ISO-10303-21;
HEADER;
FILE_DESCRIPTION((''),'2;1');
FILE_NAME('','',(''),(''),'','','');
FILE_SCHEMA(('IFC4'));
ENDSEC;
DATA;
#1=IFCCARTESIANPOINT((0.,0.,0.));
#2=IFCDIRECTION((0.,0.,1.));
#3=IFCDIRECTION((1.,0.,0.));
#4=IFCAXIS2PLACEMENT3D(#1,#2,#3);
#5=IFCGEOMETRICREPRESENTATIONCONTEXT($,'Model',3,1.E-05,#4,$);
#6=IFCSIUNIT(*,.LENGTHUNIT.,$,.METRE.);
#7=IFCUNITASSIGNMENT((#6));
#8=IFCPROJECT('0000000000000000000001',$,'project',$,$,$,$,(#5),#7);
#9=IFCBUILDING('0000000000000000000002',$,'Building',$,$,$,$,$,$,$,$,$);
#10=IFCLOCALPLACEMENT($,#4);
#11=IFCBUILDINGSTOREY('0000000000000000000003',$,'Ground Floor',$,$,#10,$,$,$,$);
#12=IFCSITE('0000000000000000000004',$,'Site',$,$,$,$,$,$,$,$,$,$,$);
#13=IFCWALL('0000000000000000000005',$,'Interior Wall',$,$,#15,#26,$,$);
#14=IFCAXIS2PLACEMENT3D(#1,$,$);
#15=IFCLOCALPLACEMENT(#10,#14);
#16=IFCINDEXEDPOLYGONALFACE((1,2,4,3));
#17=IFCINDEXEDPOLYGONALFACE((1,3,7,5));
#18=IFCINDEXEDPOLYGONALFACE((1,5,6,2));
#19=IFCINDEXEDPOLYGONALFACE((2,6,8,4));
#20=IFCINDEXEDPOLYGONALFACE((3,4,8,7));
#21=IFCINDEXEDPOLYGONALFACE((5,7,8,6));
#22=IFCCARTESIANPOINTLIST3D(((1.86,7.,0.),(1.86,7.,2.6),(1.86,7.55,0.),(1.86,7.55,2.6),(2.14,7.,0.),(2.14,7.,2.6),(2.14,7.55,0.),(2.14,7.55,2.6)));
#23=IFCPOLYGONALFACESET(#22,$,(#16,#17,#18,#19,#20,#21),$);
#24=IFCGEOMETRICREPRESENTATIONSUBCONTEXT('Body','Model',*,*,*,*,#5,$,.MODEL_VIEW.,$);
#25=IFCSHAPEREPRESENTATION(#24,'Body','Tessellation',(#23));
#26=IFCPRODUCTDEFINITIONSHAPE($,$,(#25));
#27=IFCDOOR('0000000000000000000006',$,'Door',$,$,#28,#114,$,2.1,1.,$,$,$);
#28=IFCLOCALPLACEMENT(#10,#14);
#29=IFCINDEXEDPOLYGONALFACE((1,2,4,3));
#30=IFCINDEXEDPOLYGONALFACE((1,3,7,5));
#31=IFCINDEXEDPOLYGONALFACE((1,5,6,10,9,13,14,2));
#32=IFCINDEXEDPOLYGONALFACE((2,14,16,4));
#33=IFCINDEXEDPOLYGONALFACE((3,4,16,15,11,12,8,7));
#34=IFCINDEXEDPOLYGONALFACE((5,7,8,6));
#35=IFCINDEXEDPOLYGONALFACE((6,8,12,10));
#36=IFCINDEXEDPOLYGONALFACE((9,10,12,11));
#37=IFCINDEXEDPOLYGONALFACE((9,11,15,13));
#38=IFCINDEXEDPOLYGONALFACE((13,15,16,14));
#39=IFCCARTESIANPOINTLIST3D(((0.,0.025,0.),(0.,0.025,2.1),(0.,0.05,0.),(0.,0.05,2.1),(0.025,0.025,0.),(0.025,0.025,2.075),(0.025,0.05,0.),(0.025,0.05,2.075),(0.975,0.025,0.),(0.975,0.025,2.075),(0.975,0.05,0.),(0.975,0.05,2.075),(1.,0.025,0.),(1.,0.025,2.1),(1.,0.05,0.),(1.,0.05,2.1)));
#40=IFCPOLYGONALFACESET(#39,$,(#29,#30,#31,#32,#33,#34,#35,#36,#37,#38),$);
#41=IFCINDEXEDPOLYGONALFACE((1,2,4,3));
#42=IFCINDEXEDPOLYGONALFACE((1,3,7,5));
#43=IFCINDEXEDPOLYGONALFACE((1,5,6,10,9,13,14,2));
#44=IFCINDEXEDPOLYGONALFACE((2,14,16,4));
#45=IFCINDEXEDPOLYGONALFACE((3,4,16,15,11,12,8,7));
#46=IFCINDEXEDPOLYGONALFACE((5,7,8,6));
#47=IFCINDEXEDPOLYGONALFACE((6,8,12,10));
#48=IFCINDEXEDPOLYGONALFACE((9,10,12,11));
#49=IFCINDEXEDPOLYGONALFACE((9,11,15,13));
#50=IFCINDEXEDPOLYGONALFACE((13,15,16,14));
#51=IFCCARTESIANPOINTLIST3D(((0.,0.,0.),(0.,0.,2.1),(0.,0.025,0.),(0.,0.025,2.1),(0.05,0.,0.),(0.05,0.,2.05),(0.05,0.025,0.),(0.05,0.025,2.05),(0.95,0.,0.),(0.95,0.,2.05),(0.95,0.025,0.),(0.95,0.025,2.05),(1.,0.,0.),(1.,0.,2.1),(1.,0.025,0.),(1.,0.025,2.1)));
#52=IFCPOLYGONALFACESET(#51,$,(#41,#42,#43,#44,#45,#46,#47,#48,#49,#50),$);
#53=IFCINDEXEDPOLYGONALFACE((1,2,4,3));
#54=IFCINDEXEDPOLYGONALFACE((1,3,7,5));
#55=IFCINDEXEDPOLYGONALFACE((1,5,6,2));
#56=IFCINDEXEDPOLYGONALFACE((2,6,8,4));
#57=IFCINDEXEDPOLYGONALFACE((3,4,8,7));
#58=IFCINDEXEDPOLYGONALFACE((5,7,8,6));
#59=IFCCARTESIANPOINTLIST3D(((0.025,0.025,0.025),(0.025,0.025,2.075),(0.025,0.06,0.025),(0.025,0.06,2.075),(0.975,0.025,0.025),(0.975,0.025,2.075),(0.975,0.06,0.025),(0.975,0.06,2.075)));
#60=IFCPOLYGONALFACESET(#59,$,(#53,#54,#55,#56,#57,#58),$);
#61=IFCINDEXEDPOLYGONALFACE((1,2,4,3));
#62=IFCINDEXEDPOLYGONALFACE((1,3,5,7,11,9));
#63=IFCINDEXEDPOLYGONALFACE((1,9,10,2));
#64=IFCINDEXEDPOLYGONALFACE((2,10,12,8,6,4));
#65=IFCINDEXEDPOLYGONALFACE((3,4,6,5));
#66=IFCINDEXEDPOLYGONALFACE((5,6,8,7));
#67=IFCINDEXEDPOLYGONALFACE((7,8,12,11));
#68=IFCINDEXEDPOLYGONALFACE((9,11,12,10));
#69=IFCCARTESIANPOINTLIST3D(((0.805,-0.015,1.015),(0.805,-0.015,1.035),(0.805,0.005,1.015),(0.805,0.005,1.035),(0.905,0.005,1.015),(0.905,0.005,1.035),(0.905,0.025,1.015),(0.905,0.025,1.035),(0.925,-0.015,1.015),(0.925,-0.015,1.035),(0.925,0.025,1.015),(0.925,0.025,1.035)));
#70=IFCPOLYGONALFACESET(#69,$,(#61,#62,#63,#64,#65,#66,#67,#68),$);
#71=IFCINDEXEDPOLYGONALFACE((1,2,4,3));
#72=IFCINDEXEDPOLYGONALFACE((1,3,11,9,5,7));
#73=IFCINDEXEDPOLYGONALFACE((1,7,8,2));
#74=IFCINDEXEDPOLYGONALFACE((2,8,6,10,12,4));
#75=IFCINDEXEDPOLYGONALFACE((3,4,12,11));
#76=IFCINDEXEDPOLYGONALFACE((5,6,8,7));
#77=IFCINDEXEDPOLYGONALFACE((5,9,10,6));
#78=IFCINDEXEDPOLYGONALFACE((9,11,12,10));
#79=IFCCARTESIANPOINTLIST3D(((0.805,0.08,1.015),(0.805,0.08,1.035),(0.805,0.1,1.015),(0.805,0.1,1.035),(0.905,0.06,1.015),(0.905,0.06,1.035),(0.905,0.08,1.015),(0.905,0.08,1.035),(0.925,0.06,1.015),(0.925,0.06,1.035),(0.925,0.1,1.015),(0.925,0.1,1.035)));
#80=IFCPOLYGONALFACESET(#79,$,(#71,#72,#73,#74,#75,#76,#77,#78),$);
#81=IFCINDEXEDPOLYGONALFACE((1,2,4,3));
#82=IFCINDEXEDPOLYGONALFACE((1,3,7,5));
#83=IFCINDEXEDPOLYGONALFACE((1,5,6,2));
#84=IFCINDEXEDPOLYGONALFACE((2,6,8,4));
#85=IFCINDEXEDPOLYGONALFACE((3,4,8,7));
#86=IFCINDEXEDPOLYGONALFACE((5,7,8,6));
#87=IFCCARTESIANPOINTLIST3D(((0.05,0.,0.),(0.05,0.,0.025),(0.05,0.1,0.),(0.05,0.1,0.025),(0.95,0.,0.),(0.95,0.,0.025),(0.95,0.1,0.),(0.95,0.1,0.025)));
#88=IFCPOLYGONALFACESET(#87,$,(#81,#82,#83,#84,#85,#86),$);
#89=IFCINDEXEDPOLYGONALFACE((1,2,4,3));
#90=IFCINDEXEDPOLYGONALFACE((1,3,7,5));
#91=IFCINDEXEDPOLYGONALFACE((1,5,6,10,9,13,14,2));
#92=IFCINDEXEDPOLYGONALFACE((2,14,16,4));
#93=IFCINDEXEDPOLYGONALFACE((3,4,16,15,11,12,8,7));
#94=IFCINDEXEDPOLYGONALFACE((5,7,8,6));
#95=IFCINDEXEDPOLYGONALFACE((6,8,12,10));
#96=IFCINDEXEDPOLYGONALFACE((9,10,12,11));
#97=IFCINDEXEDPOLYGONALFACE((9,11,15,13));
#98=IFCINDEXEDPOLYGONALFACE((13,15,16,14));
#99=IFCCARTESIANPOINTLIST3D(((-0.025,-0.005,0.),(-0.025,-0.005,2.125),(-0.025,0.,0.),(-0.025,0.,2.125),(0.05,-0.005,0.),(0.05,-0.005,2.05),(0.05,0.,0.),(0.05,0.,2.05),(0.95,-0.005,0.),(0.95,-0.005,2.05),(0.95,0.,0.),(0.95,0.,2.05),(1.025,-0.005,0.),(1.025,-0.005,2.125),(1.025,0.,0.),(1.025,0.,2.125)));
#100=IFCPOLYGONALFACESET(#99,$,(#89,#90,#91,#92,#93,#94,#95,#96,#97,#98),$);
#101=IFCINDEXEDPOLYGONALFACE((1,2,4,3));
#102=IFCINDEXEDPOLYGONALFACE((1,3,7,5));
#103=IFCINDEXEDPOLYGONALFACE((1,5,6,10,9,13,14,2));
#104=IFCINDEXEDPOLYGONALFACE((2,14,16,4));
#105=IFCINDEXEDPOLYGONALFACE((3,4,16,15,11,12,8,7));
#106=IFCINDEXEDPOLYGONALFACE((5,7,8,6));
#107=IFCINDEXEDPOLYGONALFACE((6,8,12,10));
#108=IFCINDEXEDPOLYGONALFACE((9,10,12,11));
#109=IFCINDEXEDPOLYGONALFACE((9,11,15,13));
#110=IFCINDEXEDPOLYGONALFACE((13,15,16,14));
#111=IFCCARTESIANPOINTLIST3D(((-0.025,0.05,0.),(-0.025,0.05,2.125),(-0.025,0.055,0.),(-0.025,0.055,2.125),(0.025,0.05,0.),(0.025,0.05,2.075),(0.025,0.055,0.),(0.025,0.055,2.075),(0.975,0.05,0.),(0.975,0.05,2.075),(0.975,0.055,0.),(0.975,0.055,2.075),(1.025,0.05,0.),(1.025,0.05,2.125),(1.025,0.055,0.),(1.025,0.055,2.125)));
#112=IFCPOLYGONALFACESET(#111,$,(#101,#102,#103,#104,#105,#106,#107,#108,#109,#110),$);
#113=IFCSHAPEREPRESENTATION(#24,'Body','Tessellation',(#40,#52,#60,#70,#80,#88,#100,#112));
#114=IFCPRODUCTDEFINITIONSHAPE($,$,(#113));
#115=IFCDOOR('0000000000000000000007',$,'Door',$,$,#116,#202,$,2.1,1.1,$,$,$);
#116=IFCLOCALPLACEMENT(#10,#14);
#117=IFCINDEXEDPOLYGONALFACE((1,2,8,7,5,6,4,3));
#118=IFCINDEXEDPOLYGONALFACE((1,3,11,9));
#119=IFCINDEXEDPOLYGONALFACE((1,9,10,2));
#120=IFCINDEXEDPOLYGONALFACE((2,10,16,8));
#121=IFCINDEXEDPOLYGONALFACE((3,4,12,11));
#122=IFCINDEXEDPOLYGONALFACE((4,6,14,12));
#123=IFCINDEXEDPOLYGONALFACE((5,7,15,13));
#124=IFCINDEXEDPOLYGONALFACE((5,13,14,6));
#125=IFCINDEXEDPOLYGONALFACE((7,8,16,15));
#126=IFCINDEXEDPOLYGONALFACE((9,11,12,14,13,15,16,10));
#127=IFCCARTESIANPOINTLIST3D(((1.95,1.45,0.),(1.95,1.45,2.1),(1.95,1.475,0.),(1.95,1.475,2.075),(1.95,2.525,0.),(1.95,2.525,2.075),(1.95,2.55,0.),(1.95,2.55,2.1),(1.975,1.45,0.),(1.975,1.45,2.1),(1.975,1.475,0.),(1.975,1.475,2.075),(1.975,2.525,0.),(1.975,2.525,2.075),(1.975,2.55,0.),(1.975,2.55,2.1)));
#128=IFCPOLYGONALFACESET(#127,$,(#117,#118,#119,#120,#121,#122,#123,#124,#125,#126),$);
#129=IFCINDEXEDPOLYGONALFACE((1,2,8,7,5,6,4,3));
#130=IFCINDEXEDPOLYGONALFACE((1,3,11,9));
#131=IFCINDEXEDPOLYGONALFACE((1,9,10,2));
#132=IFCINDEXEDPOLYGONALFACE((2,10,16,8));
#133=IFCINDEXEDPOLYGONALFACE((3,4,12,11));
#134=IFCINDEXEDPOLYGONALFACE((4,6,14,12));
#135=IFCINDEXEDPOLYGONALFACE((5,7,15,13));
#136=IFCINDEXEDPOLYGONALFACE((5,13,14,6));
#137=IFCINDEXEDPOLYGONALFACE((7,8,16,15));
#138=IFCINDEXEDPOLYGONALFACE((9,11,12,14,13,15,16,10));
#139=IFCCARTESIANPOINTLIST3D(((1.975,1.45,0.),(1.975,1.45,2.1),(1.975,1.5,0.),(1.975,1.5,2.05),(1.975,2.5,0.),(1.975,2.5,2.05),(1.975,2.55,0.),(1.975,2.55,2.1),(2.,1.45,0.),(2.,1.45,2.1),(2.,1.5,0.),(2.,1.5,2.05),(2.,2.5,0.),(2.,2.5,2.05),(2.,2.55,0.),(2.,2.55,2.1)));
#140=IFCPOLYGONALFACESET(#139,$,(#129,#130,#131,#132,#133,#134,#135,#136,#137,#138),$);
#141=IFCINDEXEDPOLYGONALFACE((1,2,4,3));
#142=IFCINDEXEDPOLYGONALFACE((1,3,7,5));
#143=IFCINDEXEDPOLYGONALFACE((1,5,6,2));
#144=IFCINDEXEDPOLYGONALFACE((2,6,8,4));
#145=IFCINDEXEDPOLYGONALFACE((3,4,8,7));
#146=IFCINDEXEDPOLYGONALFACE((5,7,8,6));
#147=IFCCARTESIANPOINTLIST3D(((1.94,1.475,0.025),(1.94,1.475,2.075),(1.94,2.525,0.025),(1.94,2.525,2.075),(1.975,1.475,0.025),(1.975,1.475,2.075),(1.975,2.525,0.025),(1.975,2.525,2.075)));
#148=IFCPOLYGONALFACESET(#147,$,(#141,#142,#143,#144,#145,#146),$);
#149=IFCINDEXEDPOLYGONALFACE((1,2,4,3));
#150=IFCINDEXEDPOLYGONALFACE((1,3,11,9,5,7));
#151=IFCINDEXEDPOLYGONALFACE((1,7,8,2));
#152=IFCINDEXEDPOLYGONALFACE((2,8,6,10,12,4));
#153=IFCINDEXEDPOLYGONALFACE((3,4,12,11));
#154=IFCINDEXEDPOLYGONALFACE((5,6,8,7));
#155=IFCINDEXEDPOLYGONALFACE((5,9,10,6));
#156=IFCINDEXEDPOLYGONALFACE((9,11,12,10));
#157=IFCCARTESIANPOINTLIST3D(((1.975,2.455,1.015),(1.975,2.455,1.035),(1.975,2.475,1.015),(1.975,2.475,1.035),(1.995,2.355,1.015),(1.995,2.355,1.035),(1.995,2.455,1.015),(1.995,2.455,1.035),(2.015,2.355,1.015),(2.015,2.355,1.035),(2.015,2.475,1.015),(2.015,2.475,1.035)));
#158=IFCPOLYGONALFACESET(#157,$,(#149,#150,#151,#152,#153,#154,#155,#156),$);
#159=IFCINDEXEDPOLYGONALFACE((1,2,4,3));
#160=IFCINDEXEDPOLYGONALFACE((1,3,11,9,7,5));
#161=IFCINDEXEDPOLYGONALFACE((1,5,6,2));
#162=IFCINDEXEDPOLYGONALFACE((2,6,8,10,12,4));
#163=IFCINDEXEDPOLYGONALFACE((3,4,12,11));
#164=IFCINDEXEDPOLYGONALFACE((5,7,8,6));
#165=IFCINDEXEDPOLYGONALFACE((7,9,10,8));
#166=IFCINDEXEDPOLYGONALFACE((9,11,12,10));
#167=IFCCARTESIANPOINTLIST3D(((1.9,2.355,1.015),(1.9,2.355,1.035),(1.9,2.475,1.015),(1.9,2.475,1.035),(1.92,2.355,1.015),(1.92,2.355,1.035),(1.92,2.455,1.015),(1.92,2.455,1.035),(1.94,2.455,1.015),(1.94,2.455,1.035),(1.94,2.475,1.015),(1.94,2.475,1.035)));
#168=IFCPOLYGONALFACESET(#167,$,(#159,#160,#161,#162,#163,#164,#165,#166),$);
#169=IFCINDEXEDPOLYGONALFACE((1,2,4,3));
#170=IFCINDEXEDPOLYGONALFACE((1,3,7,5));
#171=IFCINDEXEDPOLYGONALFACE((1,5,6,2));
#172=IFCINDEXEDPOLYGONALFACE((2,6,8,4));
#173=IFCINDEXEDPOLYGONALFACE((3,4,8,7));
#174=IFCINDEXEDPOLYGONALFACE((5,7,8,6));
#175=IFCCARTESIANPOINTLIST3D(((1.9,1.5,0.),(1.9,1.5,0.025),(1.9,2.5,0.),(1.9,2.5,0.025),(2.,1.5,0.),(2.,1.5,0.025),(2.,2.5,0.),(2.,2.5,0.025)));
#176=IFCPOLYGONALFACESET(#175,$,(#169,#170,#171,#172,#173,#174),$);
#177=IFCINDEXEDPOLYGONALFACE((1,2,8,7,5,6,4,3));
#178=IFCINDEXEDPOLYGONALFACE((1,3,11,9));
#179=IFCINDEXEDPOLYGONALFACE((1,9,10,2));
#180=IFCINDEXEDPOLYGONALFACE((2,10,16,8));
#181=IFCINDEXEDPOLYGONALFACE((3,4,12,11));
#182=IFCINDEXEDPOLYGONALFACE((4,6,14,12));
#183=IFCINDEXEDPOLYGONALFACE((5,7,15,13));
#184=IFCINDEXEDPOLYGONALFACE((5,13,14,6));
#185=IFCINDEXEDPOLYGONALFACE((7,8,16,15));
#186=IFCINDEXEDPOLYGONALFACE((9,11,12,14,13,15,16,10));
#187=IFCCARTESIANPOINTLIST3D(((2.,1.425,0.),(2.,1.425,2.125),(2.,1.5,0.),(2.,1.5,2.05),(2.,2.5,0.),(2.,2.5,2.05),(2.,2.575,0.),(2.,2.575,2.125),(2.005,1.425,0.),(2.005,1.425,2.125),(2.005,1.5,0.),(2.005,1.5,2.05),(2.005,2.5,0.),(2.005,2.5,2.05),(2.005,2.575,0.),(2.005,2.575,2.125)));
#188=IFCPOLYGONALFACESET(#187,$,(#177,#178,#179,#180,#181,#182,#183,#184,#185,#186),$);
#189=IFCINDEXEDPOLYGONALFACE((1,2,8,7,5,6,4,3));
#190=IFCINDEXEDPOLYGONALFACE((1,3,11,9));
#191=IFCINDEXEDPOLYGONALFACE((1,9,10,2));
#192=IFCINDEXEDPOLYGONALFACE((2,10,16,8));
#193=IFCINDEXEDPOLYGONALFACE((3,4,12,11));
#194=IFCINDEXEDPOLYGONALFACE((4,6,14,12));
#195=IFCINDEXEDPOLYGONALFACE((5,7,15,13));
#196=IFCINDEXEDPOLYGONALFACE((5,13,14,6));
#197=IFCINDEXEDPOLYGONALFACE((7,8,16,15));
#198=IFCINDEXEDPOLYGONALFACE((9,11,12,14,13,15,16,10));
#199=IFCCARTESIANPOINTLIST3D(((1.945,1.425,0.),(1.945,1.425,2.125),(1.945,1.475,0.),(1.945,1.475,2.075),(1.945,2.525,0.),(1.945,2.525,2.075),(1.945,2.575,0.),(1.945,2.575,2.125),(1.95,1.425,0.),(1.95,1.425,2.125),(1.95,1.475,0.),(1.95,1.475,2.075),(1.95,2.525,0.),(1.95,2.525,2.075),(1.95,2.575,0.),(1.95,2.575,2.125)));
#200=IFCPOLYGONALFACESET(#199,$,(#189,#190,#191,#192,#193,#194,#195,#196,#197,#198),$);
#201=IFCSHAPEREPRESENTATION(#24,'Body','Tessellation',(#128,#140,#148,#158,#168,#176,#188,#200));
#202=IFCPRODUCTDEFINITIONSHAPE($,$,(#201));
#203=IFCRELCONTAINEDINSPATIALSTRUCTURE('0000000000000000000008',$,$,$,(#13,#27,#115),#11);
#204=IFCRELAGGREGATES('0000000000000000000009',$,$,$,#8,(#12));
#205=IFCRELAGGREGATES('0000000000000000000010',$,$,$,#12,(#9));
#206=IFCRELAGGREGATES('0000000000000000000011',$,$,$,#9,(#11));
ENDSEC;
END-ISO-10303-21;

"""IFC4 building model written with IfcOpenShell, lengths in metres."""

from ifc_helpers import new_model, si_unit, frame, origin_with_axes, place, context, subcontext, project, spatial, line, indexed_curve, outline, extrude, element, save


model = new_model("IFC4")

# Units and contexts
model_context = context("Model", 3, precision=1e-05, world=origin_with_axes())
body_context = subcontext(model_context, "Body", "Model", "MODEL_VIEW")
ifc_project = project(units=[si_unit("LENGTHUNIT", "METRE")], contexts=[model_context])

# Site, building, storey
site = spatial("IfcSite", under=ifc_project, Name="Site")
building = spatial("IfcBuilding", under=site, Name="Building")
storey_placement = place(None, origin_with_axes())
storey = spatial("IfcBuildingStorey", under=building, at=storey_placement, Name="Ground Floor")

# Wall
wall_1_placement = place(storey_placement, frame((2.0, 7.55, 0.0), z_axis=(0.0, 0.0, 1.0), x_axis=(0.0, -1.0, 0.0)))
element("IfcWall", 1, at=wall_1_placement, inside=storey, Name="Interior Wall", context=body_context, shape_type="SweptSolid", body=[
    extrude(outline(indexed_curve([(0.0, 0.0), (0.0, 0.28), (0.55, 0.28), (0.55, 0.0), (0.0, 0.0)], self_intersect=False)), frame((0.0, -0.14, 0.0), z_axis=(0.0, 0.0, 1.0), x_axis=(1.0, 0.0, 0.0)), (0.0, 0.0, 1.0), 2.6),
])

# Doors
door_1_placement = place(storey_placement, origin_with_axes())
element("IfcDoor", 2, at=door_1_placement, inside=storey, Name="Door", OverallHeight=2.1, OverallWidth=1.0, context=body_context, shape_type="SweptSolid", body=[
    extrude(outline(indexed_curve([(0.0, 0.0), (0.0, 2.1), (1.0, 2.1), (1.0, 0.0), (0.975, 0.0), (0.975, 2.075), (0.025, 2.075), (0.025, 0.0)], segments=[line(1, 2, 3, 4, 5, 6, 7, 8, 1)])), frame((0.0, 0.025, 0.0), z_axis=(0.0, -1.0, 0.0), x_axis=(1.0, 0.0, 0.0)), (0.0, 0.0, -1.0), 0.025),
    extrude(outline(indexed_curve([(0.0, 0.0), (0.0, 2.1), (1.0, 2.1), (1.0, 0.0), (0.95, 0.0), (0.95, 2.05), (0.05, 2.05), (0.05, 0.0)], segments=[line(1, 2, 3, 4, 5, 6, 7, 8, 1)])), frame((0.0, 0.0, 0.0), z_axis=(0.0, -1.0, 0.0), x_axis=(1.0, 0.0, 0.0)), (0.0, 0.0, -1.0), 0.025),
    extrude(outline(indexed_curve([(0.0, 0.0), (0.95, 0.0), (0.95, 0.035), (0.0, 0.035)], segments=[line(1, 2, 3, 4, 1)])), frame((0.025, 0.025, 0.025), z_axis=(0.0, 0.0, 1.0), x_axis=(1.0, 0.0, 0.0)), (0.0, 0.0, 1.0), 2.05),
    extrude(outline(indexed_curve([(0.0, 0.0), (0.0, -0.04), (-0.12, -0.04), (-0.12, -0.02), (-0.02, -0.02), (-0.02, 0.0)], segments=[line(1, 2, 3, 4, 5, 6, 1)])), frame((0.925, 0.025, 1.015), z_axis=(0.0, 0.0, 1.0), x_axis=(1.0, 0.0, 0.0)), (0.0, 0.0, 1.0), 0.02),
    extrude(outline(indexed_curve([(0.0, 0.0), (0.0, 0.04), (-0.12, 0.04), (-0.12, 0.02), (-0.02, 0.02), (-0.02, 0.0)], segments=[line(1, 2, 3, 4, 5, 6, 1)])), frame((0.925, 0.06, 1.015), z_axis=(0.0, 0.0, 1.0), x_axis=(1.0, 0.0, 0.0)), (0.0, 0.0, 1.0), 0.02),
    extrude(outline(indexed_curve([(0.0, 0.0), (0.9, 0.0), (0.9, 0.1), (0.0, 0.1)], segments=[line(1, 2, 3, 4, 1)])), frame((0.05, 0.0, 0.0), z_axis=(0.0, 0.0, 1.0), x_axis=(1.0, 0.0, 0.0)), (0.0, 0.0, 1.0), 0.025),
    extrude(outline(indexed_curve([(0.0, 0.0), (0.0, 2.125), (1.05, 2.125), (1.05, 0.0), (0.975, 0.0), (0.975, 2.05), (0.075, 2.05), (0.075, 0.0)], segments=[line(1, 2, 3, 4, 5, 6, 7, 8, 1)])), frame((-0.025, -0.005, 0.0), z_axis=(0.0, -1.0, 0.0), x_axis=(1.0, 0.0, 0.0)), (0.0, 0.0, -1.0), 0.005),
    extrude(outline(indexed_curve([(0.0, 0.0), (0.0, 2.125), (1.05, 2.125), (1.05, 0.0), (1.0, 0.0), (1.0, 2.075), (0.05, 2.075), (0.05, 0.0)], segments=[line(1, 2, 3, 4, 5, 6, 7, 8, 1)])), frame((-0.025, 0.05, 0.0), z_axis=(0.0, -1.0, 0.0), x_axis=(1.0, 0.0, 0.0)), (0.0, 0.0, -1.0), 0.005),
])
door_2_placement = place(storey_placement, frame((2.0, 1.45, 0.0), z_axis=(0.0, 0.0, 1.0), x_axis=(0.0, 1.0, 0.0)))
element("IfcDoor", 3, at=door_2_placement, inside=storey, Name="Door", OverallHeight=2.1, OverallWidth=1.1, context=body_context, shape_type="SweptSolid", body=[
    extrude(outline(indexed_curve([(0.0, 0.0), (0.0, 2.1), (1.1, 2.1), (1.1, 0.0), (1.075, 0.0), (1.075, 2.075), (0.025, 2.075), (0.025, 0.0)], segments=[line(1, 2, 3, 4, 5, 6, 7, 8, 1)])), frame((0.0, 0.025, 0.0), z_axis=(0.0, -1.0, 0.0), x_axis=(1.0, 0.0, 0.0)), (0.0, 0.0, -1.0), 0.025),
    extrude(outline(indexed_curve([(0.0, 0.0), (0.0, 2.1), (1.1, 2.1), (1.1, 0.0), (1.05, 0.0), (1.05, 2.05), (0.05, 2.05), (0.05, 0.0)], segments=[line(1, 2, 3, 4, 5, 6, 7, 8, 1)])), frame((0.0, 0.0, 0.0), z_axis=(0.0, -1.0, 0.0), x_axis=(1.0, 0.0, 0.0)), (0.0, 0.0, -1.0), 0.025),
    extrude(outline(indexed_curve([(0.0, 0.0), (1.05, 0.0), (1.05, 0.035), (0.0, 0.035)], segments=[line(1, 2, 3, 4, 1)])), frame((0.025, 0.025, 0.025), z_axis=(0.0, 0.0, 1.0), x_axis=(1.0, 0.0, 0.0)), (0.0, 0.0, 1.0), 2.05),
    extrude(outline(indexed_curve([(0.0, 0.0), (0.0, -0.04), (-0.12, -0.04), (-0.12, -0.02), (-0.02, -0.02), (-0.02, 0.0)], segments=[line(1, 2, 3, 4, 5, 6, 1)])), frame((1.025, 0.025, 1.015), z_axis=(0.0, 0.0, 1.0), x_axis=(1.0, 0.0, 0.0)), (0.0, 0.0, 1.0), 0.02),
    extrude(outline(indexed_curve([(0.0, 0.0), (0.0, 0.04), (-0.12, 0.04), (-0.12, 0.02), (-0.02, 0.02), (-0.02, 0.0)], segments=[line(1, 2, 3, 4, 5, 6, 1)])), frame((1.025, 0.06, 1.015), z_axis=(0.0, 0.0, 1.0), x_axis=(1.0, 0.0, 0.0)), (0.0, 0.0, 1.0), 0.02),
    extrude(outline(indexed_curve([(0.0, 0.0), (1.0, 0.0), (1.0, 0.1), (0.0, 0.1)], segments=[line(1, 2, 3, 4, 1)])), frame((0.05, 0.0, 0.0), z_axis=(0.0, 0.0, 1.0), x_axis=(1.0, 0.0, 0.0)), (0.0, 0.0, 1.0), 0.025),
    extrude(outline(indexed_curve([(0.0, 0.0), (0.0, 2.125), (1.15, 2.125), (1.15, 0.0), (1.075, 0.0), (1.075, 2.05), (0.075, 2.05), (0.075, 0.0)], segments=[line(1, 2, 3, 4, 5, 6, 7, 8, 1)])), frame((-0.025, -0.005, 0.0), z_axis=(0.0, -1.0, 0.0), x_axis=(1.0, 0.0, 0.0)), (0.0, 0.0, -1.0), 0.005),
    extrude(outline(indexed_curve([(0.0, 0.0), (0.0, 2.125), (1.15, 2.125), (1.15, 0.0), (1.1, 0.0), (1.1, 2.075), (0.05, 2.075), (0.05, 0.0)], segments=[line(1, 2, 3, 4, 5, 6, 7, 8, 1)])), frame((-0.025, 0.05, 0.0), z_axis=(0.0, -1.0, 0.0), x_axis=(1.0, 0.0, 0.0)), (0.0, 0.0, -1.0), 0.005),
])

save(model, "model.ifc")
